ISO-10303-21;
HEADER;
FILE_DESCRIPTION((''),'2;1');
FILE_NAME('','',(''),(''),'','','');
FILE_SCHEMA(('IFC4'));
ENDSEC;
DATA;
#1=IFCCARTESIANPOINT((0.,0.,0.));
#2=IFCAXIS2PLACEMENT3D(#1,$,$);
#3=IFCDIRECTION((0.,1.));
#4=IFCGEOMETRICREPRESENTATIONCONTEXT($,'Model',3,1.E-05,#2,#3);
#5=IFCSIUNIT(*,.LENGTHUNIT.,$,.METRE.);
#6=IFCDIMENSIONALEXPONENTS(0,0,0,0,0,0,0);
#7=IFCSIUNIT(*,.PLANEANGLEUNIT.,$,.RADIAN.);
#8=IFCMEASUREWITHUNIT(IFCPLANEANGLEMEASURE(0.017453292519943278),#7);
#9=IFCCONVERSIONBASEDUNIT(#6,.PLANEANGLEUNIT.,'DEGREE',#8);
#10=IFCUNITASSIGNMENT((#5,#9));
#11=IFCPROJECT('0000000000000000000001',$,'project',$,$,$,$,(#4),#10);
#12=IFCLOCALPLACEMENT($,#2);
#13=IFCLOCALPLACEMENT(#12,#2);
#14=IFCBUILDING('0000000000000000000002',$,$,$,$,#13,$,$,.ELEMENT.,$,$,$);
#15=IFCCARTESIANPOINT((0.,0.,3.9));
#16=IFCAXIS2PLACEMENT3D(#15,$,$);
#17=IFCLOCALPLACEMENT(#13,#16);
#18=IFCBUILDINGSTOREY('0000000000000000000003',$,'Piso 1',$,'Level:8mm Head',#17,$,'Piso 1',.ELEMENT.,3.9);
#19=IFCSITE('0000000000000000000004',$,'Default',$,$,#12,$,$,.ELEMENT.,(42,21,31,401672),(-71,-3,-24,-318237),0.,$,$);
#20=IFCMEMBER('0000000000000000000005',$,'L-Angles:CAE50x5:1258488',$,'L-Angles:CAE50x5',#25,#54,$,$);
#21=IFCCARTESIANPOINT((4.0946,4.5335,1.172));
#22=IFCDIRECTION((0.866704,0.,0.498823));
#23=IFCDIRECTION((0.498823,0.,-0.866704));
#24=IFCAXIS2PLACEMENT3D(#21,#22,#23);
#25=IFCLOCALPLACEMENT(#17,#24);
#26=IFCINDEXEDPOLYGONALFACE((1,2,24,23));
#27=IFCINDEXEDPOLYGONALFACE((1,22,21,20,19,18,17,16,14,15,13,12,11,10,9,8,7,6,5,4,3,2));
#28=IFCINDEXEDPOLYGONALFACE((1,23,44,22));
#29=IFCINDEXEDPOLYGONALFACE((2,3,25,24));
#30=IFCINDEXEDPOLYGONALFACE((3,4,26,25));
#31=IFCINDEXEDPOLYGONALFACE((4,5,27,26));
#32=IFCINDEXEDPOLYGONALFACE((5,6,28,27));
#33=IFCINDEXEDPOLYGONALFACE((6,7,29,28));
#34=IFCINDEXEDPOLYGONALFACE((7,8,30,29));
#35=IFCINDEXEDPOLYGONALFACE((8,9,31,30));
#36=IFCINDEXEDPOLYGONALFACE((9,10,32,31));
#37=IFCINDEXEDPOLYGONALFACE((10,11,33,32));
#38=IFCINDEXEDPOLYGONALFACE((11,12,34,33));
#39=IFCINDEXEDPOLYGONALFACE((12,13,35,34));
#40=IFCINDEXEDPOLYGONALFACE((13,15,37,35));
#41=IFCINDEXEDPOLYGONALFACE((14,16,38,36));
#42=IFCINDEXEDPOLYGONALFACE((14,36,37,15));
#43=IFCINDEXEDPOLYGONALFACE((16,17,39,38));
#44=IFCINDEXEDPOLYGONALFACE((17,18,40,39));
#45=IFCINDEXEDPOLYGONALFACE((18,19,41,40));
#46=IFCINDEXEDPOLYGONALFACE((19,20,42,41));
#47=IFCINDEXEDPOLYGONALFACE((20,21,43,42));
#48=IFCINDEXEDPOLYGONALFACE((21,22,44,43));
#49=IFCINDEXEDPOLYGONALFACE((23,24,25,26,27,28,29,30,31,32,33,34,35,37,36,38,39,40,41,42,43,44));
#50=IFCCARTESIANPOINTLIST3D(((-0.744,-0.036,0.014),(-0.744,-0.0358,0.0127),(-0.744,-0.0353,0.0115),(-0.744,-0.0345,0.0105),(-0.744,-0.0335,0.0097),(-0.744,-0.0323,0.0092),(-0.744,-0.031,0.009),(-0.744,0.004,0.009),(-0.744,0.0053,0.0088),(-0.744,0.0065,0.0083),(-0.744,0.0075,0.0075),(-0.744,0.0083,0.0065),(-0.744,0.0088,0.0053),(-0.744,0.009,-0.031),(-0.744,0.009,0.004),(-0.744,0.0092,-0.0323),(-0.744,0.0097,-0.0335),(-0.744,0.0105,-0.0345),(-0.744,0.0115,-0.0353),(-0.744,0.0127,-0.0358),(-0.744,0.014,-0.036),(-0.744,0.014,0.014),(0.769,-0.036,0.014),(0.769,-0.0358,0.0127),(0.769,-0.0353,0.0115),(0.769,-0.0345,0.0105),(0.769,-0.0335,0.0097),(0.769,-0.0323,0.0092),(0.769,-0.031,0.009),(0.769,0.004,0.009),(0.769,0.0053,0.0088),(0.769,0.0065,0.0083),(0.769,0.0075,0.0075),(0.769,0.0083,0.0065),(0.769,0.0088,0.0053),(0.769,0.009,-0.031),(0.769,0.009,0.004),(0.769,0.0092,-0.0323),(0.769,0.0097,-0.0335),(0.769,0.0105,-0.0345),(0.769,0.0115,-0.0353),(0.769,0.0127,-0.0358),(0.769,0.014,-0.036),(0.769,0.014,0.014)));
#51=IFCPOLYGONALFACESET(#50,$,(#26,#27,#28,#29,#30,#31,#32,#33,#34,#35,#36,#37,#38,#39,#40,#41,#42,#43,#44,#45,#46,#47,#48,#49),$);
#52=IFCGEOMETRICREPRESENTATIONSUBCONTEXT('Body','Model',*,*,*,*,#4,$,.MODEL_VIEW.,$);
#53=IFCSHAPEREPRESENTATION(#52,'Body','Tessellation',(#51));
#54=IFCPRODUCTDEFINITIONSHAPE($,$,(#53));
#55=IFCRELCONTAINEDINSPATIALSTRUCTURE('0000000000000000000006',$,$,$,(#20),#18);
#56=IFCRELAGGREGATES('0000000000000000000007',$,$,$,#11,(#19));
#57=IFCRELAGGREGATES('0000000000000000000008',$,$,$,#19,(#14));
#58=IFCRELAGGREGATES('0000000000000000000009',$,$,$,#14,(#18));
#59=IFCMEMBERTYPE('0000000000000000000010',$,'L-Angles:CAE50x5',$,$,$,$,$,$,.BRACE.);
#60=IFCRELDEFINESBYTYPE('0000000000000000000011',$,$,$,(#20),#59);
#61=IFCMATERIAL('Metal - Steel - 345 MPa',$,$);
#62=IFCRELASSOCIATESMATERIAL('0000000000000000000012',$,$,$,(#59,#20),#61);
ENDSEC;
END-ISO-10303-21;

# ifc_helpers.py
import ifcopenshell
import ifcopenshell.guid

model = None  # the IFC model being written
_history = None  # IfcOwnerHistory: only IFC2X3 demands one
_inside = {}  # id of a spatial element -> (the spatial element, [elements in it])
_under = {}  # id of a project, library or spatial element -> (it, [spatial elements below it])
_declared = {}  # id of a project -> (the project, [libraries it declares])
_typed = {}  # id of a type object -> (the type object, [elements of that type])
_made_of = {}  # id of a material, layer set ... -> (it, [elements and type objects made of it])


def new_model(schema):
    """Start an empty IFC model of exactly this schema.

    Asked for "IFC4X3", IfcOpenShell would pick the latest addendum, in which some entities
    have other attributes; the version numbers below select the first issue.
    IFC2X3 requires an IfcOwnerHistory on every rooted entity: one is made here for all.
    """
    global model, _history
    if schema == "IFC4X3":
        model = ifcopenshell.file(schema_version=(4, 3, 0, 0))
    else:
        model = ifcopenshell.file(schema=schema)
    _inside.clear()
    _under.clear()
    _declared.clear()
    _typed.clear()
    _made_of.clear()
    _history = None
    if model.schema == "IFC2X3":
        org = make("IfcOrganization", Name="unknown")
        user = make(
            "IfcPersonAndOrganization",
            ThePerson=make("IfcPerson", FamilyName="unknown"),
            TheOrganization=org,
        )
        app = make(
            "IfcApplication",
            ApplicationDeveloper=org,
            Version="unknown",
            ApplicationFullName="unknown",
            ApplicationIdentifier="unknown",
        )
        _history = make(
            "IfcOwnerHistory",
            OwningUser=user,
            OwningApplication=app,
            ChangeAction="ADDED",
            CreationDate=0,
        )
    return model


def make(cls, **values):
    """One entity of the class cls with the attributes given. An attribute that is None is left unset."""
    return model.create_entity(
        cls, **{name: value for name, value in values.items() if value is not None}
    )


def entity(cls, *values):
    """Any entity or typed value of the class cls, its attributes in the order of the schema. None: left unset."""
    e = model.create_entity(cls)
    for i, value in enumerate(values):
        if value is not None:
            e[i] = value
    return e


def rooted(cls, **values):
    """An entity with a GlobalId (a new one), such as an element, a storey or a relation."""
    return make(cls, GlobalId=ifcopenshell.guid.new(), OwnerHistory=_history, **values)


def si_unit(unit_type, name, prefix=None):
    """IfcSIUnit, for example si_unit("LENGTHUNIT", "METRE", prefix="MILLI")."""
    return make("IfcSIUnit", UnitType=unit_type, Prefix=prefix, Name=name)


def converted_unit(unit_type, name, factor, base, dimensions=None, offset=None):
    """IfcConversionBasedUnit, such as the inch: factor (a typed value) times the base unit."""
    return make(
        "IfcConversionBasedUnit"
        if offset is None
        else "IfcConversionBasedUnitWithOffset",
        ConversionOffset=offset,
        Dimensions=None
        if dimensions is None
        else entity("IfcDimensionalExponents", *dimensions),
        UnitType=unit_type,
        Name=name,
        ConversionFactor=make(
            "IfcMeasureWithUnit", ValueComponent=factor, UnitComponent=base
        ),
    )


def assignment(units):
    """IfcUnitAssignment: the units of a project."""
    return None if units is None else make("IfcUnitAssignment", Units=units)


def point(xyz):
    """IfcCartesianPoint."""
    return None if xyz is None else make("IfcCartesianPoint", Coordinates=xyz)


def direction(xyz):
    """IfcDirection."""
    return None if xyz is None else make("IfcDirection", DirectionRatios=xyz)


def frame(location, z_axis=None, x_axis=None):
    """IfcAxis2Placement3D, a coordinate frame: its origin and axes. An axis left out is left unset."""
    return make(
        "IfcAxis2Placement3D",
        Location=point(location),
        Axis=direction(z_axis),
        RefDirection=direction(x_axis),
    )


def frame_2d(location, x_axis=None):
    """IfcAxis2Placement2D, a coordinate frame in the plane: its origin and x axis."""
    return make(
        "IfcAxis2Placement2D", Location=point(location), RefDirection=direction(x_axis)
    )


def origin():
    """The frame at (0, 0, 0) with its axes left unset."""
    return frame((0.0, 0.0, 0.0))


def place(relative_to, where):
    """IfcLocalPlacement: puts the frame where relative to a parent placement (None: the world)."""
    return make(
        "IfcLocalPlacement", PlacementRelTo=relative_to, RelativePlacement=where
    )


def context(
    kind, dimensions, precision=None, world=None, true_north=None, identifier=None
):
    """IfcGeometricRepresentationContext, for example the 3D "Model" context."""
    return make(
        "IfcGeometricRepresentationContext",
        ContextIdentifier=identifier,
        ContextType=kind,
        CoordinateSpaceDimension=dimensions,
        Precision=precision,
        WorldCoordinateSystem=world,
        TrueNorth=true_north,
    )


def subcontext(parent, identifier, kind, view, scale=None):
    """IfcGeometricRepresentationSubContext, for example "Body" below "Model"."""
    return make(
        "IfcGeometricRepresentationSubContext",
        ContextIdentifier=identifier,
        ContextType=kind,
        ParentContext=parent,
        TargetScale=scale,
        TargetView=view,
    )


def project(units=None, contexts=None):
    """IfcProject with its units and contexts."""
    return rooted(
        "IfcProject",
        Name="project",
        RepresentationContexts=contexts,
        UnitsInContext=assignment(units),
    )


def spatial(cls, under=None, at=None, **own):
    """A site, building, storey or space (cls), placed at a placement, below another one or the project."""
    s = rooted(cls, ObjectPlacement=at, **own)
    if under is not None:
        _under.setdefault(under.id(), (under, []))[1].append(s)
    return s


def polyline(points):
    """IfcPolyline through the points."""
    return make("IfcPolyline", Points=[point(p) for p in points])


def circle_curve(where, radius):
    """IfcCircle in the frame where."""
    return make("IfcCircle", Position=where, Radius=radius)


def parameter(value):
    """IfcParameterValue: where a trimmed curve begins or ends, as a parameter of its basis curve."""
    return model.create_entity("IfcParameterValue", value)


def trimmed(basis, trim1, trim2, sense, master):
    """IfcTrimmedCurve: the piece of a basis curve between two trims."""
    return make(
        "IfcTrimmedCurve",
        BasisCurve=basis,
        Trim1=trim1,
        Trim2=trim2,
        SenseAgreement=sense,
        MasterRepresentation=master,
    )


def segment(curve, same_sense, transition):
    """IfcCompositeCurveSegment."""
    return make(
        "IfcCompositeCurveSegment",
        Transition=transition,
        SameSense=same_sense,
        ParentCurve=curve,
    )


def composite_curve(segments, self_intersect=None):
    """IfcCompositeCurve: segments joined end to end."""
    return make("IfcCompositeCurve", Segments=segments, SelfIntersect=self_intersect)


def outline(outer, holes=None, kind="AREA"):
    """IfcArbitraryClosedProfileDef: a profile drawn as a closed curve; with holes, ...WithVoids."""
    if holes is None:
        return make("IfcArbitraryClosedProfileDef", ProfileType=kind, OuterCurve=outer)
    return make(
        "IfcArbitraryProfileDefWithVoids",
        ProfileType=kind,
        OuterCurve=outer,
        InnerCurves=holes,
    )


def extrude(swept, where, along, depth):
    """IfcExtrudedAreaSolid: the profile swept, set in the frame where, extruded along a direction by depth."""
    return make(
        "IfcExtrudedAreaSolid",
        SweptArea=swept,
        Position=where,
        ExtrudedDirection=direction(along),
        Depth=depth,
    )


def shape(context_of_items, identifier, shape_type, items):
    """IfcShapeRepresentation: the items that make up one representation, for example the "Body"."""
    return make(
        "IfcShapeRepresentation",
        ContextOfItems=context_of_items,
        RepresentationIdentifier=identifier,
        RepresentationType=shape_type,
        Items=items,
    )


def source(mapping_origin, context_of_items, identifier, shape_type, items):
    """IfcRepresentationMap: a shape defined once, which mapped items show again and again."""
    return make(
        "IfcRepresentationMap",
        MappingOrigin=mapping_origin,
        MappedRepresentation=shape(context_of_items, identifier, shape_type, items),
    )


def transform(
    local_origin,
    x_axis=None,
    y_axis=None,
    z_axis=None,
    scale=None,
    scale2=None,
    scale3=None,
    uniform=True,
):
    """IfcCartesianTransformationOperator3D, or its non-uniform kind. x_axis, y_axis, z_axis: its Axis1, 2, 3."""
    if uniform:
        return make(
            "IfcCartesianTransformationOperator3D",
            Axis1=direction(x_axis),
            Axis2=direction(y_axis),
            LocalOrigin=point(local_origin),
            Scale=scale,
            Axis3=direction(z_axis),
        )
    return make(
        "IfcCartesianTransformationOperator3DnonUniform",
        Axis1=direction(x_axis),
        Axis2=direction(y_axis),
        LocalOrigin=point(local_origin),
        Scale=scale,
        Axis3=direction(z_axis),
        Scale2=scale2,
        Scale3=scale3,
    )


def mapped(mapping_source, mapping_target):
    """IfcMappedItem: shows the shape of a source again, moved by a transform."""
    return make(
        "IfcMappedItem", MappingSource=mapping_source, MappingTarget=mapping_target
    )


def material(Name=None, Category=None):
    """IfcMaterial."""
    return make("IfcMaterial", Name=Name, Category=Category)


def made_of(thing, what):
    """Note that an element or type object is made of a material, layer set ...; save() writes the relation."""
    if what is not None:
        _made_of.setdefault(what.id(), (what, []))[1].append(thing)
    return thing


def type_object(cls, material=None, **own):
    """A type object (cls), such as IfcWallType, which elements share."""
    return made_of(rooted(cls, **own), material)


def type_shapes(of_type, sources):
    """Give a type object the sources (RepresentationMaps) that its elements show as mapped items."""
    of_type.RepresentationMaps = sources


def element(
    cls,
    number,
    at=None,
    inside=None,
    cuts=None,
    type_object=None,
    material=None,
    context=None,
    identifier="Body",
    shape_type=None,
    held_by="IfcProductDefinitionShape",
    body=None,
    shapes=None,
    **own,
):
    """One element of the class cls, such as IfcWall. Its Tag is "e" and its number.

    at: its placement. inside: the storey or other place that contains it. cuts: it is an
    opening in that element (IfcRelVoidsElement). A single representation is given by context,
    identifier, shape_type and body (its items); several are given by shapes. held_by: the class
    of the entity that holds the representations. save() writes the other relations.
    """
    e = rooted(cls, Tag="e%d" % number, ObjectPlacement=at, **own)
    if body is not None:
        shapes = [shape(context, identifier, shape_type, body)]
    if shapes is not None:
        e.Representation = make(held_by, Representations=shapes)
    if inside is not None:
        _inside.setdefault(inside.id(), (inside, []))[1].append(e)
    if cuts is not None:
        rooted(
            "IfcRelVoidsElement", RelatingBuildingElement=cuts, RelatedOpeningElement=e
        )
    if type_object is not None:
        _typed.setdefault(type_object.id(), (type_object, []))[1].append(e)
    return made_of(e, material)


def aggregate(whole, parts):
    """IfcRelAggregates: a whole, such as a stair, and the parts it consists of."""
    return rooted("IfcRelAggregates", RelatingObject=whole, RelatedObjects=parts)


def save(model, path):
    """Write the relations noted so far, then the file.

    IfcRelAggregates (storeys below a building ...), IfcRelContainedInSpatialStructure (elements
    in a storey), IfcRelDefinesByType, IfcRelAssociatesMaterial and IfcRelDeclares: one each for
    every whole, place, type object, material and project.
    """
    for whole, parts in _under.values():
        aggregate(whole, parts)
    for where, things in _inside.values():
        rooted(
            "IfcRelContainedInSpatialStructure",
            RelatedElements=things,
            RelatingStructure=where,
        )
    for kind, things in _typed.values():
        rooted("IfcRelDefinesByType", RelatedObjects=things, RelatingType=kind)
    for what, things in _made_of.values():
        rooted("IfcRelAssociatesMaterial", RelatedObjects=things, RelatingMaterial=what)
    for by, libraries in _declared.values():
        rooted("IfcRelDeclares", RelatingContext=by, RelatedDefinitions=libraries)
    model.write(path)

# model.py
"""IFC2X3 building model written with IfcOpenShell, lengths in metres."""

from ifc_helpers import new_model, entity, si_unit, converted_unit, direction, frame, frame_2d, origin, place, context, subcontext, project, spatial, polyline, circle_curve, parameter, trimmed, segment, composite_curve, outline, extrude, source, transform, mapped, material, type_object, type_shapes, element, save


model = new_model("IFC2X3")

# Units and contexts
model_context = context("Model", 3, precision=1e-05, world=origin(), true_north=direction((0.0, 1.0)))
body_context = subcontext(model_context, "Body", "Model", "MODEL_VIEW")
ifc_project = project(units=[si_unit("LENGTHUNIT", "METRE"), converted_unit("PLANEANGLEUNIT", "DEGREE", entity("IfcPlaneAngleMeasure", 0.017453292519943278), si_unit("PLANEANGLEUNIT", "RADIAN"), dimensions=[0, 0, 0, 0, 0, 0, 0])], contexts=[model_context])

# Site, building, storey
site_placement = place(None, origin())
site = spatial("IfcSite", under=ifc_project, at=site_placement, Name="Default", CompositionType="ELEMENT", RefLatitude=(42, 21, 31, 401672), RefLongitude=(-71, -3, -24, -318237), RefElevation=0.0)
building_placement = place(site_placement, origin())
building = spatial("IfcBuilding", under=site, at=building_placement, CompositionType="ELEMENT")
storey_placement = place(building_placement, frame((0.0, 0.0, 3.9)))
storey = spatial("IfcBuildingStorey", under=building, at=storey_placement, Name="Piso 1", ObjectType="Level:8mm Head", LongName="Piso 1", CompositionType="ELEMENT", Elevation=3.9)

# Shared definitions
ifc_material_1 = material(Name="Metal - Steel - 345 MPa")

# Member
member_type_1 = type_object("IfcMemberType", Name="L-Angles:CAE50x5", PredefinedType="BRACE", material=ifc_material_1)
shared_shape_1 = source(origin(), body_context, "Body", "SweptSolid", [
    extrude(outline(composite_curve([segment(polyline([(-0.0164, -0.0164), (0.0336, -0.0164)]), True, "CONTINUOUS"), segment(trimmed(circle_curve(frame_2d((0.0286, -0.0164), x_axis=(1.0, 0.0)), 0.005), [parameter(0.0)], [parameter(90.0)], True, "PARAMETER"), True, "CONTINUOUS"), segment(polyline([(0.0286, -0.0114), (-0.0064, -0.0114)]), True, "CONTINUOUS"), segment(trimmed(circle_curve(frame_2d((-0.0064, -0.0064), x_axis=(1.0, 0.0)), 0.005), [parameter(180.0)], [parameter(270.0)], True, "PARAMETER"), False, "CONTINUOUS"), segment(polyline([(-0.0114, -0.0064), (-0.0114, 0.0286)]), True, "CONTINUOUS"), segment(trimmed(circle_curve(frame_2d((-0.0164, 0.0286), x_axis=(1.0, 0.0)), 0.005), [parameter(0.0)], [parameter(90.0)], True, "PARAMETER"), True, "CONTINUOUS"), segment(polyline([(-0.0164, 0.0336), (-0.0164, -0.0164)]), True, "CONTINUOUS")], self_intersect=False)), frame((-0.744, -0.0024, -0.0024), z_axis=(1.0, 0.0, 0.0), x_axis=(0.0, -1.0, 0.0)), (0.0, 0.0, 1.0), 1.513),
])
type_shapes(member_type_1, [shared_shape_1])
member_1_placement = place(storey_placement, frame((4.0946, 4.5335, 1.172), z_axis=(0.866704, 0.0, 0.498823), x_axis=(0.498823, 0.0, -0.866704)))
element("IfcMember", 1, at=member_1_placement, inside=storey, type_object=member_type_1, material=ifc_material_1, Name="L-Angles:CAE50x5:1258488", ObjectType="L-Angles:CAE50x5", context=body_context, shape_type="MappedRepresentation", body=[
    mapped(shared_shape_1, transform((0.0, 0.0, 0.0), scale=1.0)),
])

save(model, "model.ifc")
